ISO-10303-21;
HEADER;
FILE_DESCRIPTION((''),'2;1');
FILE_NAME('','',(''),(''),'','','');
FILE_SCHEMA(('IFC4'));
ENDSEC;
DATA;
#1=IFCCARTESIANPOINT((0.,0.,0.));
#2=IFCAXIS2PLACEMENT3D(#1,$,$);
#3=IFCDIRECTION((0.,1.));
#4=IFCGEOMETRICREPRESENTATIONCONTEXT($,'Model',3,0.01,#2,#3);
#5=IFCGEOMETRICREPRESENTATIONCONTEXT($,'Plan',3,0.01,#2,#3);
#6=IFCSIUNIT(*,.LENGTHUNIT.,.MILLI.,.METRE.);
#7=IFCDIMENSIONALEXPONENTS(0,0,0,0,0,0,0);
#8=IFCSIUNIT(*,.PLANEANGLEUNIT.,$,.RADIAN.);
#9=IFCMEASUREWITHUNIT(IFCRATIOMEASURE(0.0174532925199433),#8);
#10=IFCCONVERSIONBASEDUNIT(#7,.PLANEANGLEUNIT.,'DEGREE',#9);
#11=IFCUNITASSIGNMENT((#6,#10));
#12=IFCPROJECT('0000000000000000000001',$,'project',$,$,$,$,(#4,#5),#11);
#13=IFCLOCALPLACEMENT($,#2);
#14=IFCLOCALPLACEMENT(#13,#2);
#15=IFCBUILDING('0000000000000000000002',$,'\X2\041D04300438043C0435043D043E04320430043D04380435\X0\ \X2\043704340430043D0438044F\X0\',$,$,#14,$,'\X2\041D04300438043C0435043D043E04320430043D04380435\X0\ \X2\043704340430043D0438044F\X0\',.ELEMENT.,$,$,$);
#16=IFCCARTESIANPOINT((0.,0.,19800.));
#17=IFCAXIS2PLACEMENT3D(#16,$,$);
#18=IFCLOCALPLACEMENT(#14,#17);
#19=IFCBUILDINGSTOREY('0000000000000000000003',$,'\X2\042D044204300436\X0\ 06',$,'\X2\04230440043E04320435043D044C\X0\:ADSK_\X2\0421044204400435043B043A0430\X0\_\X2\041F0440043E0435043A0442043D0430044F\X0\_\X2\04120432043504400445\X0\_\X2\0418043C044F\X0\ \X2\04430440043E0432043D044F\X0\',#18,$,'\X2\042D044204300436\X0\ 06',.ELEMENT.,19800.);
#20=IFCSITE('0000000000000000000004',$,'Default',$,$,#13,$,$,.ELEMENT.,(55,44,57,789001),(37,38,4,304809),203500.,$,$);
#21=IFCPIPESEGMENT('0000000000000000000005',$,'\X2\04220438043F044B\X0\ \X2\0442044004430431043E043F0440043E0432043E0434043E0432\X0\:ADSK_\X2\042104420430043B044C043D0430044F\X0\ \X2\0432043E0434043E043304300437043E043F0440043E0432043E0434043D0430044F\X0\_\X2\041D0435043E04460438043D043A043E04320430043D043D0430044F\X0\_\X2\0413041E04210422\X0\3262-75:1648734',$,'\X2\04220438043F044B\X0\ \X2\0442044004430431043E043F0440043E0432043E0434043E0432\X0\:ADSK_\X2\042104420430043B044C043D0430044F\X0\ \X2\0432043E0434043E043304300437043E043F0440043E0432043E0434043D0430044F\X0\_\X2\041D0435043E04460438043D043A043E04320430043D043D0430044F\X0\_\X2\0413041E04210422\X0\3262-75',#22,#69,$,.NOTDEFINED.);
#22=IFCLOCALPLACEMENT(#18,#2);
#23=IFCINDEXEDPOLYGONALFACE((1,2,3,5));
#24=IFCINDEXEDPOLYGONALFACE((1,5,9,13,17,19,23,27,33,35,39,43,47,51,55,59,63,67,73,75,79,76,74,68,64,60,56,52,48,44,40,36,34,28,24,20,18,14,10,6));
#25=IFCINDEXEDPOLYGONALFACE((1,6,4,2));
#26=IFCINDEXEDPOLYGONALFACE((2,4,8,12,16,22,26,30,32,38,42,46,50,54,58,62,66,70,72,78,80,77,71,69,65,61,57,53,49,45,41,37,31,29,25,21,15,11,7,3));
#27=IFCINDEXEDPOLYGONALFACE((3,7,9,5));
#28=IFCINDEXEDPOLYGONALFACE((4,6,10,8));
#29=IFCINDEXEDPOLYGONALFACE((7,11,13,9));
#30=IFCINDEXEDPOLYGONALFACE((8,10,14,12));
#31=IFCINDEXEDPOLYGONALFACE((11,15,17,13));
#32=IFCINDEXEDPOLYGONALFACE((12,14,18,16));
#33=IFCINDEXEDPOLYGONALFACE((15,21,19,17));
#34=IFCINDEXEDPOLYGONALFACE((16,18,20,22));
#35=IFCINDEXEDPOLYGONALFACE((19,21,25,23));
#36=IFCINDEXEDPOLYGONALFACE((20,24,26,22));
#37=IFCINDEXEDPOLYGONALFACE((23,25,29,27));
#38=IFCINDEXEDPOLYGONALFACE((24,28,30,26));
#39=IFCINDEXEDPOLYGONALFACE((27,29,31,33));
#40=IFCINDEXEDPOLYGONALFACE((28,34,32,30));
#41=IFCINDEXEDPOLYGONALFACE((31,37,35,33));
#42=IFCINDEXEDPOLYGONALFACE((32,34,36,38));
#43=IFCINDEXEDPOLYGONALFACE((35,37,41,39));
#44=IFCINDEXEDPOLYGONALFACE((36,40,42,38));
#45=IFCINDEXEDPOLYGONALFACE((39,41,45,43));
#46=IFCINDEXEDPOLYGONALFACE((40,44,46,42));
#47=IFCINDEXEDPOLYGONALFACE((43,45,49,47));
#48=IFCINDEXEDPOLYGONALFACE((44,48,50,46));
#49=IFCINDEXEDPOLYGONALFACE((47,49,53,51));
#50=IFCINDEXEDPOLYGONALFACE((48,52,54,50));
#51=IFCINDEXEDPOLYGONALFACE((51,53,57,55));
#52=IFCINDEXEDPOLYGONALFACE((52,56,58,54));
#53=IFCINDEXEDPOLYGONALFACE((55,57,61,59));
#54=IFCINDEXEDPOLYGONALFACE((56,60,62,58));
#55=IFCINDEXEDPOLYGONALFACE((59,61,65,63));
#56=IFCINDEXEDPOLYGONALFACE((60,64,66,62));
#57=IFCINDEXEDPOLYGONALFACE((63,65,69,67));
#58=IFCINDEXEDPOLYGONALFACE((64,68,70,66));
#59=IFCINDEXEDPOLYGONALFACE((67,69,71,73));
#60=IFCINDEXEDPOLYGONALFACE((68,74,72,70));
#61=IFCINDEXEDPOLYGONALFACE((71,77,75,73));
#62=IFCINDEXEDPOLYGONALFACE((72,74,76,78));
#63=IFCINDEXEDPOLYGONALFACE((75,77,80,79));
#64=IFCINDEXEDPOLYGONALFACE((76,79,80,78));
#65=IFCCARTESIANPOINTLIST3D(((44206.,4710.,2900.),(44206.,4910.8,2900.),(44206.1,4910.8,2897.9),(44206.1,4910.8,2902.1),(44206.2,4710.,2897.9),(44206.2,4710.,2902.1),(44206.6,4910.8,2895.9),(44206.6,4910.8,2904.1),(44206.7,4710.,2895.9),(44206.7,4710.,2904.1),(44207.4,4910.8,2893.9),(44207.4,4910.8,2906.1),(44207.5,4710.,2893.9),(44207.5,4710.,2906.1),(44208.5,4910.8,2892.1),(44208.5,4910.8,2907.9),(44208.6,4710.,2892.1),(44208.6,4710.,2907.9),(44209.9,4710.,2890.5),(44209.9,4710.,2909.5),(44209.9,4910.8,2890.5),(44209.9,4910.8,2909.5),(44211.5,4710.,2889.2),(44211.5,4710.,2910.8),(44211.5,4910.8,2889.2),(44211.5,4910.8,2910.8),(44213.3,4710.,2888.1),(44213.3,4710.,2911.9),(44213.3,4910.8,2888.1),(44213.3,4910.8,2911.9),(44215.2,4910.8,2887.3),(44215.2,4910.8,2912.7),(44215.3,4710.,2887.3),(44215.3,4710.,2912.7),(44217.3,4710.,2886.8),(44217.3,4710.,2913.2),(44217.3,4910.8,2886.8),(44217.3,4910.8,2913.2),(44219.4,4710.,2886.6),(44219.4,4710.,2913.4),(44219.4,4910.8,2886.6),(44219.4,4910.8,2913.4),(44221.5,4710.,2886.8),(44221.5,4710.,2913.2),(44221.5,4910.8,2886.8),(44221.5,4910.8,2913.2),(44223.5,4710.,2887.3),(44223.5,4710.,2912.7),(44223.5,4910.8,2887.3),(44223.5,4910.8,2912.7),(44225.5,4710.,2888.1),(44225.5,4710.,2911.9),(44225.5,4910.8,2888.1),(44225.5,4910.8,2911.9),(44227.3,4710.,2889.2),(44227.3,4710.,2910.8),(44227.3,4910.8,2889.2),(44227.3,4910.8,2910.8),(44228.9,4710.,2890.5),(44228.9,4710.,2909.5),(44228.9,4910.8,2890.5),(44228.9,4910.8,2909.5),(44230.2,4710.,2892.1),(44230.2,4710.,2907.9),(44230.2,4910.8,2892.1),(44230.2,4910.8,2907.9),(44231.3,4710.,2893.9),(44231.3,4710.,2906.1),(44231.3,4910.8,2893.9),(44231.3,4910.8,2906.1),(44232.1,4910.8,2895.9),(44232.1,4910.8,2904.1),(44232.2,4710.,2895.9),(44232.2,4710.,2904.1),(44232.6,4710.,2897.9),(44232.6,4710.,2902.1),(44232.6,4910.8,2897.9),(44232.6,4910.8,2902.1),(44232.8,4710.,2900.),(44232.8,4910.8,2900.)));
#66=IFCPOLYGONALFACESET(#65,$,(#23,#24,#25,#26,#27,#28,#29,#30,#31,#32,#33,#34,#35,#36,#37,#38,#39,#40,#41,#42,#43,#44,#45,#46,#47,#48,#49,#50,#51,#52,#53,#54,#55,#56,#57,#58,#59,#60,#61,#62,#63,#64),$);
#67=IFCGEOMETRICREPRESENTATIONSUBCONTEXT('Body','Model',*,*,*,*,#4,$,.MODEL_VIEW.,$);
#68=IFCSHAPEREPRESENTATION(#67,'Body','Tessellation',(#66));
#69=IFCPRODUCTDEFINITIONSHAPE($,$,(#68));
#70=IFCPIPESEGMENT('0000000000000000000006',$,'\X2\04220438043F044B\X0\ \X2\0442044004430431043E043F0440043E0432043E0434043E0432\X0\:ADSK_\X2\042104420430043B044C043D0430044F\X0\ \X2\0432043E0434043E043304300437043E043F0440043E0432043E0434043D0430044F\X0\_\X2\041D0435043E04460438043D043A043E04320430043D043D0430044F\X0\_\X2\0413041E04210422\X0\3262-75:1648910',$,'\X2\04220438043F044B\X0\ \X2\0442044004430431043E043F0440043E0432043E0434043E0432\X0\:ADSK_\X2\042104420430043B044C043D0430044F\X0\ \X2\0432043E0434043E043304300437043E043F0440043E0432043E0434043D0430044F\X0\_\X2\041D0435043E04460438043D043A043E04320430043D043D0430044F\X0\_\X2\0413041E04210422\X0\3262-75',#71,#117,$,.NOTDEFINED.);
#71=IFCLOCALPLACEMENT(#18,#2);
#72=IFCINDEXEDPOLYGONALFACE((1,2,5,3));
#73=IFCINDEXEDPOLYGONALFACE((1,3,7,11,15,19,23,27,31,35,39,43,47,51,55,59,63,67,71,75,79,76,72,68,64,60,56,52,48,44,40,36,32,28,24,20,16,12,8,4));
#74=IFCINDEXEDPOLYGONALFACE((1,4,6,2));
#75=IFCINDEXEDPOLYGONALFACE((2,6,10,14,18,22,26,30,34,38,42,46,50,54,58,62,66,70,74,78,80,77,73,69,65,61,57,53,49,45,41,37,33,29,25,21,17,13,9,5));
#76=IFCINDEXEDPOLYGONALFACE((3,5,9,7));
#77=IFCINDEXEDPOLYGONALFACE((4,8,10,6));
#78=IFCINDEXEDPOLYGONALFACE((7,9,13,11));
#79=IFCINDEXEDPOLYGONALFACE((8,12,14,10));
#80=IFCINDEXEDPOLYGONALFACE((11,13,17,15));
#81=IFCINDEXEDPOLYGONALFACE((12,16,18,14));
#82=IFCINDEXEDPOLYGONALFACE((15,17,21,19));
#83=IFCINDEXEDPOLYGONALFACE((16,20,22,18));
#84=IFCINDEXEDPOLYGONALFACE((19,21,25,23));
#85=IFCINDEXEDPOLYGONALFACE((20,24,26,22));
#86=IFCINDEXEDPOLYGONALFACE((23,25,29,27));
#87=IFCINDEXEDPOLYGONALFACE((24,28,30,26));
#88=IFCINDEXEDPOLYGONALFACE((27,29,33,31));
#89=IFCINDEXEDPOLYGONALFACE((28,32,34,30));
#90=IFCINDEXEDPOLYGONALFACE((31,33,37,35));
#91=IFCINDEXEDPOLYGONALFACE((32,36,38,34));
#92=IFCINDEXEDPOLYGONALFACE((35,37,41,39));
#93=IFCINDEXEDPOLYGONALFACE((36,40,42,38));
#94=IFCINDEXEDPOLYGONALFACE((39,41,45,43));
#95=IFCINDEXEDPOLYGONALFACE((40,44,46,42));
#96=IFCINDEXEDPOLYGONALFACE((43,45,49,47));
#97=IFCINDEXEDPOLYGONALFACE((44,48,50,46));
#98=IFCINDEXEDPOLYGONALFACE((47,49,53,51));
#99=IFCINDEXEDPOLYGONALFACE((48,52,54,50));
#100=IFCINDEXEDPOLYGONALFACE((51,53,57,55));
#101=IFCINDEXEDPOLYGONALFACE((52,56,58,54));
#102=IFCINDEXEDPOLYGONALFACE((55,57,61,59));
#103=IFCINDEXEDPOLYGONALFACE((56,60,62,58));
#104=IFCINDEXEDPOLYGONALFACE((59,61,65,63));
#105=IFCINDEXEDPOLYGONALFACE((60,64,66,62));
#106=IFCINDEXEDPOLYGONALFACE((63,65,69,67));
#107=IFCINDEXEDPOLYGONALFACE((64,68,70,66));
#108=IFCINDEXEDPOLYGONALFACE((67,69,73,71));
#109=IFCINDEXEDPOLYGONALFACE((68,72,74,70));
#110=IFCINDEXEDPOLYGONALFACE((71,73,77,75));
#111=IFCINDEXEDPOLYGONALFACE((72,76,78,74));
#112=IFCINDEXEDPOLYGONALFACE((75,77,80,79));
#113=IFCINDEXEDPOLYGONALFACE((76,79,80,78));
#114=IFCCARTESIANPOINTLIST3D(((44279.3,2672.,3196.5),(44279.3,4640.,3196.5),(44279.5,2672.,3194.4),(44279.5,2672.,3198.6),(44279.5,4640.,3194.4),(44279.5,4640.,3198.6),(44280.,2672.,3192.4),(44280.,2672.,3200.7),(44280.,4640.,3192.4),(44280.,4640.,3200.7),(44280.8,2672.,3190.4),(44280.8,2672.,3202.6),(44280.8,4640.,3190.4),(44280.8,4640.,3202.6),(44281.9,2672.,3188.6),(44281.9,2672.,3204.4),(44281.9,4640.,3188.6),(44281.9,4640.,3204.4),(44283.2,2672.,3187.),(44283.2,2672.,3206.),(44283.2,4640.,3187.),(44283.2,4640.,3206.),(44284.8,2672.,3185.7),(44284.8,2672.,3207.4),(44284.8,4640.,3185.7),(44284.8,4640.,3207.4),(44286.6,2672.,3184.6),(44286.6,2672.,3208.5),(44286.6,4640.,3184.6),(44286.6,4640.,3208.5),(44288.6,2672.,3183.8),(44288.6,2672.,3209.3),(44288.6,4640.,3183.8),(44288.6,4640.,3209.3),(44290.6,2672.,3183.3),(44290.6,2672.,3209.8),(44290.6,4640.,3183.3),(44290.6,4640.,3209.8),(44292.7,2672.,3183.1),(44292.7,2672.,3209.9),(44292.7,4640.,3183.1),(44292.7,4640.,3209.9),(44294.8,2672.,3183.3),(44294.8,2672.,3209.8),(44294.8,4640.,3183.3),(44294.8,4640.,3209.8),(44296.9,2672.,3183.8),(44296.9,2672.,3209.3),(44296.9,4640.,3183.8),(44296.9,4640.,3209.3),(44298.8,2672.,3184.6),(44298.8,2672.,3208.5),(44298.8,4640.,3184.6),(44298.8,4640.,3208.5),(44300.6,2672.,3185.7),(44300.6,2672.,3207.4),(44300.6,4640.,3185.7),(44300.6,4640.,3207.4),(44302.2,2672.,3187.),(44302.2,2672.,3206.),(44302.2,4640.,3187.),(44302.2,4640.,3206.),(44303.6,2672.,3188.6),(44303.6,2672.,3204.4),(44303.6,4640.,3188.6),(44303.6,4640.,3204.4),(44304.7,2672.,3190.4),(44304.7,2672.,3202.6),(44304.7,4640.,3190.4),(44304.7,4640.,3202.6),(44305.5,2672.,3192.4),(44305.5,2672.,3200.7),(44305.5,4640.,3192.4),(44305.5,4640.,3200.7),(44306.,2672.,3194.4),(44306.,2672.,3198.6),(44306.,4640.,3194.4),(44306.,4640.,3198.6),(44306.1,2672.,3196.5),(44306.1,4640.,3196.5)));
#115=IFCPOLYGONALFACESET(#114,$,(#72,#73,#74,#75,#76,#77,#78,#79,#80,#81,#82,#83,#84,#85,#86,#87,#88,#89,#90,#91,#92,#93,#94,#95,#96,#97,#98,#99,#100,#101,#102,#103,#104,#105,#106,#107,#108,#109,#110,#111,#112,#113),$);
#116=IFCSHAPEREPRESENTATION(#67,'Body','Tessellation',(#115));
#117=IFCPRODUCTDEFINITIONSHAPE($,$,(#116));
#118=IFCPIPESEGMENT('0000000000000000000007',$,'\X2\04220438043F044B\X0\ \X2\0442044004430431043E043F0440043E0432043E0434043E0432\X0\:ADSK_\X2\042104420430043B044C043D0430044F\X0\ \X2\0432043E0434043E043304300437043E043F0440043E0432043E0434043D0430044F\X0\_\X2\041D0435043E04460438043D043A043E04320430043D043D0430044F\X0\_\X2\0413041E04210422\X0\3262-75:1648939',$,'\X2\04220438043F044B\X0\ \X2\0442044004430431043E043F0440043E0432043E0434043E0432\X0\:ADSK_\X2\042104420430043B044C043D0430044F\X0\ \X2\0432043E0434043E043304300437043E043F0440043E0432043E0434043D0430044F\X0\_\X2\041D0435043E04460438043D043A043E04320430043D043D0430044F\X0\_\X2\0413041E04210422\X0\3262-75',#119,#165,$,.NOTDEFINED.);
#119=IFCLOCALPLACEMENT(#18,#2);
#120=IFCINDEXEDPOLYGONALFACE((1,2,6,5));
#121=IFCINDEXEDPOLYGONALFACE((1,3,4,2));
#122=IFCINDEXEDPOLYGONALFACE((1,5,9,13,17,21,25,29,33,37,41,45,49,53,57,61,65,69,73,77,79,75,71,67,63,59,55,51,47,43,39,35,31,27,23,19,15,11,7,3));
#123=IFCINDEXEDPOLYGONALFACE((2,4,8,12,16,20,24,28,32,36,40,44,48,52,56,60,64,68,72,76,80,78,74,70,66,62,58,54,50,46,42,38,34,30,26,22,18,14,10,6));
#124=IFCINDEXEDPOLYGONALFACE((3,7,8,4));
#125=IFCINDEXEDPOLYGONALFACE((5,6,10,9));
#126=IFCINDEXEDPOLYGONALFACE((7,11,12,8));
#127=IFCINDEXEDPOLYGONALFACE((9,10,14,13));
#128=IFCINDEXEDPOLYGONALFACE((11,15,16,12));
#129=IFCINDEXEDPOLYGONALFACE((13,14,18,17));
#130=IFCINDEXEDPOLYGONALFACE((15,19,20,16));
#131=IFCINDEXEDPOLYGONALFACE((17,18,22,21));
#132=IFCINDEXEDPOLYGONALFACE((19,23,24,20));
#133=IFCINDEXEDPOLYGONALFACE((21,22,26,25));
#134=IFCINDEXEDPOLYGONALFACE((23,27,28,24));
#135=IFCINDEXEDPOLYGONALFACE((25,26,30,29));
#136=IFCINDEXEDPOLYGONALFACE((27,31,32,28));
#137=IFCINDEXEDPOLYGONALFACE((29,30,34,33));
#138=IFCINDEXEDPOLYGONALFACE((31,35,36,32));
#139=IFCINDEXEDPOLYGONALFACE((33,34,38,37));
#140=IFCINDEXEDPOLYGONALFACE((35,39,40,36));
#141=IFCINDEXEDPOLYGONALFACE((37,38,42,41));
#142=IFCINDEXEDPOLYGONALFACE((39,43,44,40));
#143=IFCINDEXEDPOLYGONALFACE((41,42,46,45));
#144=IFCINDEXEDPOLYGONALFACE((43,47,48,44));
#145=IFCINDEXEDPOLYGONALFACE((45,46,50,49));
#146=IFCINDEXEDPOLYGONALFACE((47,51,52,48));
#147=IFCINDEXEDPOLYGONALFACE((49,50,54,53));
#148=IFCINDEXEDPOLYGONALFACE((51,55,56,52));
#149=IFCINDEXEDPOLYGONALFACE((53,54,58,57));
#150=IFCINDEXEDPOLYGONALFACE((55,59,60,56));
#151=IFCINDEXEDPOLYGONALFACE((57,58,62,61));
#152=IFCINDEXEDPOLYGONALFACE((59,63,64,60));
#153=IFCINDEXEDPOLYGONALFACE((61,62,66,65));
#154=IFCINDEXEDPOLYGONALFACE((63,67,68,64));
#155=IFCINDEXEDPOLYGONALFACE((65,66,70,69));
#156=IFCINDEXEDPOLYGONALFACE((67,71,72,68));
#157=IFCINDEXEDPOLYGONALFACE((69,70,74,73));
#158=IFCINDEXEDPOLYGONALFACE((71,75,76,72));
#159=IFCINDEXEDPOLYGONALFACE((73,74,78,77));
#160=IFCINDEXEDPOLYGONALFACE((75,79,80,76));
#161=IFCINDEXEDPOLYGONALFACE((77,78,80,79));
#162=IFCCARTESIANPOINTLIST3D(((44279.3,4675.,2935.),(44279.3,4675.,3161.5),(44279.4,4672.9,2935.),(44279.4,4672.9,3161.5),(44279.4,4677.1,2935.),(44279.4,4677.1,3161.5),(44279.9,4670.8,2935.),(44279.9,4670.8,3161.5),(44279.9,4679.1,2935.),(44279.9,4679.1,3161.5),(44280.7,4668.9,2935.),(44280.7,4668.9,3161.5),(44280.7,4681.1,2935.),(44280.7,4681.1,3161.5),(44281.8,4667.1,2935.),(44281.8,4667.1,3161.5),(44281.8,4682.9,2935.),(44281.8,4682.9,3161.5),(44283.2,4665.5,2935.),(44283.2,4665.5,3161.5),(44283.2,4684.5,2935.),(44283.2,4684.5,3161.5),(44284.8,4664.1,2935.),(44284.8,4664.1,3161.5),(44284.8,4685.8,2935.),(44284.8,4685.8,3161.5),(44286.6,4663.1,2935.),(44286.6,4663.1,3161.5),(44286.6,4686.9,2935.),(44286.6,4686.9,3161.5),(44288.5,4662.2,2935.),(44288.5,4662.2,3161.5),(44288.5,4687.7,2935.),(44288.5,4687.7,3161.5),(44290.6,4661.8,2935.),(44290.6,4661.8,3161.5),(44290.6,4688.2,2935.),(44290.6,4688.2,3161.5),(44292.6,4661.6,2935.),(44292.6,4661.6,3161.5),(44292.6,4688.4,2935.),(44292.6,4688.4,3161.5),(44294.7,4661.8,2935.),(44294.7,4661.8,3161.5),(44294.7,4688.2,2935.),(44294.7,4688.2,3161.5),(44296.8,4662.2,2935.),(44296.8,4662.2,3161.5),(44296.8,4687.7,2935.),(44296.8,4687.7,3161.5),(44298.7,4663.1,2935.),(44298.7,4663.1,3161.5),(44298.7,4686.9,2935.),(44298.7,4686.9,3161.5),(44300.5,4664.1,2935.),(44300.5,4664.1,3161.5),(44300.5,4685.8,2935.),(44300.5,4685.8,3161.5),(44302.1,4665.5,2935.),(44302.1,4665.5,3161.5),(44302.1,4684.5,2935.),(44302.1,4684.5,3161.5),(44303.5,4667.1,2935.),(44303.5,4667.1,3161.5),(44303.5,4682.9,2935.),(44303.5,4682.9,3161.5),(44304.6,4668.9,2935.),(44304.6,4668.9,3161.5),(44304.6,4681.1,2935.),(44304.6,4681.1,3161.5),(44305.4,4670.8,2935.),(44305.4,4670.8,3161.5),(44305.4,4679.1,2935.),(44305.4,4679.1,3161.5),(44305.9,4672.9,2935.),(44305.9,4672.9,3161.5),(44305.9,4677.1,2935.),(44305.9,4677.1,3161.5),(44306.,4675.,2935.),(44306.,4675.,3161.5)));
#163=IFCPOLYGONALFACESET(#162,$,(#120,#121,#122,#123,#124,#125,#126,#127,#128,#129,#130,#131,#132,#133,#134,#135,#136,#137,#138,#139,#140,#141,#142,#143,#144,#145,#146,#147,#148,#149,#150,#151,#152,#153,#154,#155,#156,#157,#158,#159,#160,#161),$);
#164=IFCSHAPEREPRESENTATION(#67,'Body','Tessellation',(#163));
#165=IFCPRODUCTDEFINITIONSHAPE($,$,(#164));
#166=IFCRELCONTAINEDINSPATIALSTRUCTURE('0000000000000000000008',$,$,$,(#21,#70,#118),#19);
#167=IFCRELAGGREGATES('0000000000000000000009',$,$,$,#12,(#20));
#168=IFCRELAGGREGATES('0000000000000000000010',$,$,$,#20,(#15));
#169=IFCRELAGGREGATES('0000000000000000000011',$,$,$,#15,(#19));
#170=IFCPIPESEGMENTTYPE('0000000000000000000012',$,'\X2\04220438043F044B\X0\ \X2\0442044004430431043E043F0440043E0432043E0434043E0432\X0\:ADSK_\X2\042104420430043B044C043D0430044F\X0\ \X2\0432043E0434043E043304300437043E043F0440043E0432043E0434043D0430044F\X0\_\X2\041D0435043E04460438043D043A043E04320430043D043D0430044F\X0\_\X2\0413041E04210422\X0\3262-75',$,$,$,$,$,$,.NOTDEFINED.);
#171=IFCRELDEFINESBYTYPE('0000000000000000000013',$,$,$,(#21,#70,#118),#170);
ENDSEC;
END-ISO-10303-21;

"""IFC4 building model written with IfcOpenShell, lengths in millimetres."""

from ifc_helpers import new_model, entity, si_unit, converted_unit, direction, frame, origin, place, context, subcontext, project, spatial, indexed_curve, outline, extrude, type_object, element, save


model = new_model("IFC4")

# Units and contexts
model_context = context("Model", 3, precision=0.01, world=origin(), true_north=direction((0.0, 1.0)))
plan_context = context("Plan", 3, precision=0.01, world=origin(), true_north=direction((0.0, 1.0)))
body_context = subcontext(model_context, "Body", "Model", "MODEL_VIEW")
ifc_project = project(units=[si_unit("LENGTHUNIT", "METRE", prefix="MILLI"), converted_unit("PLANEANGLEUNIT", "DEGREE", entity("IfcRatioMeasure", 0.0174532925199433), si_unit("PLANEANGLEUNIT", "RADIAN"), dimensions=[0, 0, 0, 0, 0, 0, 0])], contexts=[model_context, plan_context])

# Site, building, storey
site_placement = place(None, origin())
site = spatial("IfcSite", under=ifc_project, at=site_placement, Name="Default", CompositionType="ELEMENT", RefLatitude=(55, 44, 57, 789001), RefLongitude=(37, 38, 4, 304809), RefElevation=203500.0)
building_placement = place(site_placement, origin())
building = spatial("IfcBuilding", under=site, at=building_placement, Name="Наименование здания", LongName="Наименование здания", CompositionType="ELEMENT")
storey_placement = place(building_placement, frame((0.0, 0.0, 19800.0)))
storey = spatial("IfcBuildingStorey", under=building, at=storey_placement, Name="Этаж 06", ObjectType="Уровень:ADSK_Стрелка_Проектная_Вверх_Имя уровня", LongName="Этаж 06", CompositionType="ELEMENT", Elevation=19800.0)

# Pipe segments
pipe_segment_type = type_object("IfcPipeSegmentType", Name="Типы трубопроводов:ADSK_Стальная водогазопроводная_Неоцинкованная_ГОСТ3262-75", PredefinedType="NOTDEFINED")
placement = place(storey_placement, origin())
element("IfcPipeSegment", 1, at=placement, inside=storey, type_object=pipe_segment_type, Name="Типы трубопроводов:ADSK_Стальная водогазопроводная_Неоцинкованная_ГОСТ3262-75:1648734", ObjectType="Типы трубопроводов:ADSK_Стальная водогазопроводная_Неоцинкованная_ГОСТ3262-75", PredefinedType="NOTDEFINED", context=body_context, shape_type="SweptSolid", body=[
    extrude(outline(indexed_curve([(13.4, 0.0), (13.2, 2.1), (12.7, 4.1), (11.9, 6.1), (10.8, 7.9), (9.5, 9.5), (7.9, 10.8), (6.1, 11.9), (4.1, 12.7), (2.1, 13.2), (0.0, 13.4), (-2.1, 13.2), (-4.1, 12.7), (-6.1, 11.9), (-7.9, 10.8), (-9.5, 9.5), (-10.8, 7.9), (-11.9, 6.1), (-12.7, 4.1), (-13.2, 2.1), (-13.4, 0.0), (-13.2, -2.1), (-12.7, -4.1), (-11.9, -6.1), (-10.8, -7.9), (-9.5, -9.5), (-7.9, -10.8), (-6.1, -11.9), (-4.1, -12.7), (-2.1, -13.2), (0.0, -13.4), (2.1, -13.2), (4.1, -12.7), (6.1, -11.9), (7.9, -10.8), (9.5, -9.5), (10.8, -7.9), (11.9, -6.1), (12.7, -4.1), (13.2, -2.1), (13.4, 0.0)], self_intersect=False)), frame((44219.4, 4910.8, 2900.0), z_axis=(0.000137, -1.0, 0.0), x_axis=(-1.0, -0.000137, 0.0)), (0.0, 0.0, 1.0), 200.8),
])
element("IfcPipeSegment", 2, at=placement, inside=storey, type_object=pipe_segment_type, Name="Типы трубопроводов:ADSK_Стальная водогазопроводная_Неоцинкованная_ГОСТ3262-75:1648910", ObjectType="Типы трубопроводов:ADSK_Стальная водогазопроводная_Неоцинкованная_ГОСТ3262-75", PredefinedType="NOTDEFINED", context=body_context, shape_type="SweptSolid", body=[
    extrude(outline(indexed_curve([(13.4, 0.0), (13.2, 2.1), (12.7, 4.1), (11.9, 6.1), (10.8, 7.9), (9.5, 9.5), (7.9, 10.8), (6.1, 11.9), (4.1, 12.7), (2.1, 13.2), (0.0, 13.4), (-2.1, 13.2), (-4.1, 12.7), (-6.1, 11.9), (-7.9, 10.8), (-9.5, 9.5), (-10.8, 7.9), (-11.9, 6.1), (-12.7, 4.1), (-13.2, 2.1), (-13.4, 0.0), (-13.2, -2.1), (-12.7, -4.1), (-11.9, -6.1), (-10.8, -7.9), (-9.5, -9.5), (-7.9, -10.8), (-6.1, -11.9), (-4.1, -12.7), (-2.1, -13.2), (0.0, -13.4), (2.1, -13.2), (4.1, -12.7), (6.1, -11.9), (7.9, -10.8), (9.5, -9.5), (10.8, -7.9), (11.9, -6.1), (12.7, -4.1), (13.2, -2.1), (13.4, 0.0)], self_intersect=False)), frame((44292.7, 2672.0, 3196.5), z_axis=(0.0, 1.0, 0.0), x_axis=(1.0, 0.0, 0.0)), (0.0, 0.0, 1.0), 1968.0),
])
element("IfcPipeSegment", 3, at=placement, inside=storey, type_object=pipe_segment_type, Name="Типы трубопроводов:ADSK_Стальная водогазопроводная_Неоцинкованная_ГОСТ3262-75:1648939", ObjectType="Типы трубопроводов:ADSK_Стальная водогазопроводная_Неоцинкованная_ГОСТ3262-75", PredefinedType="NOTDEFINED", context=body_context, shape_type="SweptSolid", body=[
    extrude(outline(indexed_curve([(13.4, 0.0), (13.2, 2.1), (12.7, 4.1), (11.9, 6.1), (10.8, 7.9), (9.5, 9.5), (7.9, 10.8), (6.1, 11.9), (4.1, 12.7), (2.1, 13.2), (0.0, 13.4), (-2.1, 13.2), (-4.1, 12.7), (-6.1, 11.9), (-7.9, 10.8), (-9.5, 9.5), (-10.8, 7.9), (-11.9, 6.1), (-12.7, 4.1), (-13.2, 2.1), (-13.4, 0.0), (-13.2, -2.1), (-12.7, -4.1), (-11.9, -6.1), (-10.8, -7.9), (-9.5, -9.5), (-7.9, -10.8), (-6.1, -11.9), (-4.1, -12.7), (-2.1, -13.2), (0.0, -13.4), (2.1, -13.2), (4.1, -12.7), (6.1, -11.9), (7.9, -10.8), (9.5, -9.5), (10.8, -7.9), (11.9, -6.1), (12.7, -4.1), (13.2, -2.1), (13.4, 0.0)], self_intersect=False)), frame((44292.7, 4675.0, 2935.0)), (0.0, 0.0, 1.0), 226.5),
])

save(model, "model.ifc")
